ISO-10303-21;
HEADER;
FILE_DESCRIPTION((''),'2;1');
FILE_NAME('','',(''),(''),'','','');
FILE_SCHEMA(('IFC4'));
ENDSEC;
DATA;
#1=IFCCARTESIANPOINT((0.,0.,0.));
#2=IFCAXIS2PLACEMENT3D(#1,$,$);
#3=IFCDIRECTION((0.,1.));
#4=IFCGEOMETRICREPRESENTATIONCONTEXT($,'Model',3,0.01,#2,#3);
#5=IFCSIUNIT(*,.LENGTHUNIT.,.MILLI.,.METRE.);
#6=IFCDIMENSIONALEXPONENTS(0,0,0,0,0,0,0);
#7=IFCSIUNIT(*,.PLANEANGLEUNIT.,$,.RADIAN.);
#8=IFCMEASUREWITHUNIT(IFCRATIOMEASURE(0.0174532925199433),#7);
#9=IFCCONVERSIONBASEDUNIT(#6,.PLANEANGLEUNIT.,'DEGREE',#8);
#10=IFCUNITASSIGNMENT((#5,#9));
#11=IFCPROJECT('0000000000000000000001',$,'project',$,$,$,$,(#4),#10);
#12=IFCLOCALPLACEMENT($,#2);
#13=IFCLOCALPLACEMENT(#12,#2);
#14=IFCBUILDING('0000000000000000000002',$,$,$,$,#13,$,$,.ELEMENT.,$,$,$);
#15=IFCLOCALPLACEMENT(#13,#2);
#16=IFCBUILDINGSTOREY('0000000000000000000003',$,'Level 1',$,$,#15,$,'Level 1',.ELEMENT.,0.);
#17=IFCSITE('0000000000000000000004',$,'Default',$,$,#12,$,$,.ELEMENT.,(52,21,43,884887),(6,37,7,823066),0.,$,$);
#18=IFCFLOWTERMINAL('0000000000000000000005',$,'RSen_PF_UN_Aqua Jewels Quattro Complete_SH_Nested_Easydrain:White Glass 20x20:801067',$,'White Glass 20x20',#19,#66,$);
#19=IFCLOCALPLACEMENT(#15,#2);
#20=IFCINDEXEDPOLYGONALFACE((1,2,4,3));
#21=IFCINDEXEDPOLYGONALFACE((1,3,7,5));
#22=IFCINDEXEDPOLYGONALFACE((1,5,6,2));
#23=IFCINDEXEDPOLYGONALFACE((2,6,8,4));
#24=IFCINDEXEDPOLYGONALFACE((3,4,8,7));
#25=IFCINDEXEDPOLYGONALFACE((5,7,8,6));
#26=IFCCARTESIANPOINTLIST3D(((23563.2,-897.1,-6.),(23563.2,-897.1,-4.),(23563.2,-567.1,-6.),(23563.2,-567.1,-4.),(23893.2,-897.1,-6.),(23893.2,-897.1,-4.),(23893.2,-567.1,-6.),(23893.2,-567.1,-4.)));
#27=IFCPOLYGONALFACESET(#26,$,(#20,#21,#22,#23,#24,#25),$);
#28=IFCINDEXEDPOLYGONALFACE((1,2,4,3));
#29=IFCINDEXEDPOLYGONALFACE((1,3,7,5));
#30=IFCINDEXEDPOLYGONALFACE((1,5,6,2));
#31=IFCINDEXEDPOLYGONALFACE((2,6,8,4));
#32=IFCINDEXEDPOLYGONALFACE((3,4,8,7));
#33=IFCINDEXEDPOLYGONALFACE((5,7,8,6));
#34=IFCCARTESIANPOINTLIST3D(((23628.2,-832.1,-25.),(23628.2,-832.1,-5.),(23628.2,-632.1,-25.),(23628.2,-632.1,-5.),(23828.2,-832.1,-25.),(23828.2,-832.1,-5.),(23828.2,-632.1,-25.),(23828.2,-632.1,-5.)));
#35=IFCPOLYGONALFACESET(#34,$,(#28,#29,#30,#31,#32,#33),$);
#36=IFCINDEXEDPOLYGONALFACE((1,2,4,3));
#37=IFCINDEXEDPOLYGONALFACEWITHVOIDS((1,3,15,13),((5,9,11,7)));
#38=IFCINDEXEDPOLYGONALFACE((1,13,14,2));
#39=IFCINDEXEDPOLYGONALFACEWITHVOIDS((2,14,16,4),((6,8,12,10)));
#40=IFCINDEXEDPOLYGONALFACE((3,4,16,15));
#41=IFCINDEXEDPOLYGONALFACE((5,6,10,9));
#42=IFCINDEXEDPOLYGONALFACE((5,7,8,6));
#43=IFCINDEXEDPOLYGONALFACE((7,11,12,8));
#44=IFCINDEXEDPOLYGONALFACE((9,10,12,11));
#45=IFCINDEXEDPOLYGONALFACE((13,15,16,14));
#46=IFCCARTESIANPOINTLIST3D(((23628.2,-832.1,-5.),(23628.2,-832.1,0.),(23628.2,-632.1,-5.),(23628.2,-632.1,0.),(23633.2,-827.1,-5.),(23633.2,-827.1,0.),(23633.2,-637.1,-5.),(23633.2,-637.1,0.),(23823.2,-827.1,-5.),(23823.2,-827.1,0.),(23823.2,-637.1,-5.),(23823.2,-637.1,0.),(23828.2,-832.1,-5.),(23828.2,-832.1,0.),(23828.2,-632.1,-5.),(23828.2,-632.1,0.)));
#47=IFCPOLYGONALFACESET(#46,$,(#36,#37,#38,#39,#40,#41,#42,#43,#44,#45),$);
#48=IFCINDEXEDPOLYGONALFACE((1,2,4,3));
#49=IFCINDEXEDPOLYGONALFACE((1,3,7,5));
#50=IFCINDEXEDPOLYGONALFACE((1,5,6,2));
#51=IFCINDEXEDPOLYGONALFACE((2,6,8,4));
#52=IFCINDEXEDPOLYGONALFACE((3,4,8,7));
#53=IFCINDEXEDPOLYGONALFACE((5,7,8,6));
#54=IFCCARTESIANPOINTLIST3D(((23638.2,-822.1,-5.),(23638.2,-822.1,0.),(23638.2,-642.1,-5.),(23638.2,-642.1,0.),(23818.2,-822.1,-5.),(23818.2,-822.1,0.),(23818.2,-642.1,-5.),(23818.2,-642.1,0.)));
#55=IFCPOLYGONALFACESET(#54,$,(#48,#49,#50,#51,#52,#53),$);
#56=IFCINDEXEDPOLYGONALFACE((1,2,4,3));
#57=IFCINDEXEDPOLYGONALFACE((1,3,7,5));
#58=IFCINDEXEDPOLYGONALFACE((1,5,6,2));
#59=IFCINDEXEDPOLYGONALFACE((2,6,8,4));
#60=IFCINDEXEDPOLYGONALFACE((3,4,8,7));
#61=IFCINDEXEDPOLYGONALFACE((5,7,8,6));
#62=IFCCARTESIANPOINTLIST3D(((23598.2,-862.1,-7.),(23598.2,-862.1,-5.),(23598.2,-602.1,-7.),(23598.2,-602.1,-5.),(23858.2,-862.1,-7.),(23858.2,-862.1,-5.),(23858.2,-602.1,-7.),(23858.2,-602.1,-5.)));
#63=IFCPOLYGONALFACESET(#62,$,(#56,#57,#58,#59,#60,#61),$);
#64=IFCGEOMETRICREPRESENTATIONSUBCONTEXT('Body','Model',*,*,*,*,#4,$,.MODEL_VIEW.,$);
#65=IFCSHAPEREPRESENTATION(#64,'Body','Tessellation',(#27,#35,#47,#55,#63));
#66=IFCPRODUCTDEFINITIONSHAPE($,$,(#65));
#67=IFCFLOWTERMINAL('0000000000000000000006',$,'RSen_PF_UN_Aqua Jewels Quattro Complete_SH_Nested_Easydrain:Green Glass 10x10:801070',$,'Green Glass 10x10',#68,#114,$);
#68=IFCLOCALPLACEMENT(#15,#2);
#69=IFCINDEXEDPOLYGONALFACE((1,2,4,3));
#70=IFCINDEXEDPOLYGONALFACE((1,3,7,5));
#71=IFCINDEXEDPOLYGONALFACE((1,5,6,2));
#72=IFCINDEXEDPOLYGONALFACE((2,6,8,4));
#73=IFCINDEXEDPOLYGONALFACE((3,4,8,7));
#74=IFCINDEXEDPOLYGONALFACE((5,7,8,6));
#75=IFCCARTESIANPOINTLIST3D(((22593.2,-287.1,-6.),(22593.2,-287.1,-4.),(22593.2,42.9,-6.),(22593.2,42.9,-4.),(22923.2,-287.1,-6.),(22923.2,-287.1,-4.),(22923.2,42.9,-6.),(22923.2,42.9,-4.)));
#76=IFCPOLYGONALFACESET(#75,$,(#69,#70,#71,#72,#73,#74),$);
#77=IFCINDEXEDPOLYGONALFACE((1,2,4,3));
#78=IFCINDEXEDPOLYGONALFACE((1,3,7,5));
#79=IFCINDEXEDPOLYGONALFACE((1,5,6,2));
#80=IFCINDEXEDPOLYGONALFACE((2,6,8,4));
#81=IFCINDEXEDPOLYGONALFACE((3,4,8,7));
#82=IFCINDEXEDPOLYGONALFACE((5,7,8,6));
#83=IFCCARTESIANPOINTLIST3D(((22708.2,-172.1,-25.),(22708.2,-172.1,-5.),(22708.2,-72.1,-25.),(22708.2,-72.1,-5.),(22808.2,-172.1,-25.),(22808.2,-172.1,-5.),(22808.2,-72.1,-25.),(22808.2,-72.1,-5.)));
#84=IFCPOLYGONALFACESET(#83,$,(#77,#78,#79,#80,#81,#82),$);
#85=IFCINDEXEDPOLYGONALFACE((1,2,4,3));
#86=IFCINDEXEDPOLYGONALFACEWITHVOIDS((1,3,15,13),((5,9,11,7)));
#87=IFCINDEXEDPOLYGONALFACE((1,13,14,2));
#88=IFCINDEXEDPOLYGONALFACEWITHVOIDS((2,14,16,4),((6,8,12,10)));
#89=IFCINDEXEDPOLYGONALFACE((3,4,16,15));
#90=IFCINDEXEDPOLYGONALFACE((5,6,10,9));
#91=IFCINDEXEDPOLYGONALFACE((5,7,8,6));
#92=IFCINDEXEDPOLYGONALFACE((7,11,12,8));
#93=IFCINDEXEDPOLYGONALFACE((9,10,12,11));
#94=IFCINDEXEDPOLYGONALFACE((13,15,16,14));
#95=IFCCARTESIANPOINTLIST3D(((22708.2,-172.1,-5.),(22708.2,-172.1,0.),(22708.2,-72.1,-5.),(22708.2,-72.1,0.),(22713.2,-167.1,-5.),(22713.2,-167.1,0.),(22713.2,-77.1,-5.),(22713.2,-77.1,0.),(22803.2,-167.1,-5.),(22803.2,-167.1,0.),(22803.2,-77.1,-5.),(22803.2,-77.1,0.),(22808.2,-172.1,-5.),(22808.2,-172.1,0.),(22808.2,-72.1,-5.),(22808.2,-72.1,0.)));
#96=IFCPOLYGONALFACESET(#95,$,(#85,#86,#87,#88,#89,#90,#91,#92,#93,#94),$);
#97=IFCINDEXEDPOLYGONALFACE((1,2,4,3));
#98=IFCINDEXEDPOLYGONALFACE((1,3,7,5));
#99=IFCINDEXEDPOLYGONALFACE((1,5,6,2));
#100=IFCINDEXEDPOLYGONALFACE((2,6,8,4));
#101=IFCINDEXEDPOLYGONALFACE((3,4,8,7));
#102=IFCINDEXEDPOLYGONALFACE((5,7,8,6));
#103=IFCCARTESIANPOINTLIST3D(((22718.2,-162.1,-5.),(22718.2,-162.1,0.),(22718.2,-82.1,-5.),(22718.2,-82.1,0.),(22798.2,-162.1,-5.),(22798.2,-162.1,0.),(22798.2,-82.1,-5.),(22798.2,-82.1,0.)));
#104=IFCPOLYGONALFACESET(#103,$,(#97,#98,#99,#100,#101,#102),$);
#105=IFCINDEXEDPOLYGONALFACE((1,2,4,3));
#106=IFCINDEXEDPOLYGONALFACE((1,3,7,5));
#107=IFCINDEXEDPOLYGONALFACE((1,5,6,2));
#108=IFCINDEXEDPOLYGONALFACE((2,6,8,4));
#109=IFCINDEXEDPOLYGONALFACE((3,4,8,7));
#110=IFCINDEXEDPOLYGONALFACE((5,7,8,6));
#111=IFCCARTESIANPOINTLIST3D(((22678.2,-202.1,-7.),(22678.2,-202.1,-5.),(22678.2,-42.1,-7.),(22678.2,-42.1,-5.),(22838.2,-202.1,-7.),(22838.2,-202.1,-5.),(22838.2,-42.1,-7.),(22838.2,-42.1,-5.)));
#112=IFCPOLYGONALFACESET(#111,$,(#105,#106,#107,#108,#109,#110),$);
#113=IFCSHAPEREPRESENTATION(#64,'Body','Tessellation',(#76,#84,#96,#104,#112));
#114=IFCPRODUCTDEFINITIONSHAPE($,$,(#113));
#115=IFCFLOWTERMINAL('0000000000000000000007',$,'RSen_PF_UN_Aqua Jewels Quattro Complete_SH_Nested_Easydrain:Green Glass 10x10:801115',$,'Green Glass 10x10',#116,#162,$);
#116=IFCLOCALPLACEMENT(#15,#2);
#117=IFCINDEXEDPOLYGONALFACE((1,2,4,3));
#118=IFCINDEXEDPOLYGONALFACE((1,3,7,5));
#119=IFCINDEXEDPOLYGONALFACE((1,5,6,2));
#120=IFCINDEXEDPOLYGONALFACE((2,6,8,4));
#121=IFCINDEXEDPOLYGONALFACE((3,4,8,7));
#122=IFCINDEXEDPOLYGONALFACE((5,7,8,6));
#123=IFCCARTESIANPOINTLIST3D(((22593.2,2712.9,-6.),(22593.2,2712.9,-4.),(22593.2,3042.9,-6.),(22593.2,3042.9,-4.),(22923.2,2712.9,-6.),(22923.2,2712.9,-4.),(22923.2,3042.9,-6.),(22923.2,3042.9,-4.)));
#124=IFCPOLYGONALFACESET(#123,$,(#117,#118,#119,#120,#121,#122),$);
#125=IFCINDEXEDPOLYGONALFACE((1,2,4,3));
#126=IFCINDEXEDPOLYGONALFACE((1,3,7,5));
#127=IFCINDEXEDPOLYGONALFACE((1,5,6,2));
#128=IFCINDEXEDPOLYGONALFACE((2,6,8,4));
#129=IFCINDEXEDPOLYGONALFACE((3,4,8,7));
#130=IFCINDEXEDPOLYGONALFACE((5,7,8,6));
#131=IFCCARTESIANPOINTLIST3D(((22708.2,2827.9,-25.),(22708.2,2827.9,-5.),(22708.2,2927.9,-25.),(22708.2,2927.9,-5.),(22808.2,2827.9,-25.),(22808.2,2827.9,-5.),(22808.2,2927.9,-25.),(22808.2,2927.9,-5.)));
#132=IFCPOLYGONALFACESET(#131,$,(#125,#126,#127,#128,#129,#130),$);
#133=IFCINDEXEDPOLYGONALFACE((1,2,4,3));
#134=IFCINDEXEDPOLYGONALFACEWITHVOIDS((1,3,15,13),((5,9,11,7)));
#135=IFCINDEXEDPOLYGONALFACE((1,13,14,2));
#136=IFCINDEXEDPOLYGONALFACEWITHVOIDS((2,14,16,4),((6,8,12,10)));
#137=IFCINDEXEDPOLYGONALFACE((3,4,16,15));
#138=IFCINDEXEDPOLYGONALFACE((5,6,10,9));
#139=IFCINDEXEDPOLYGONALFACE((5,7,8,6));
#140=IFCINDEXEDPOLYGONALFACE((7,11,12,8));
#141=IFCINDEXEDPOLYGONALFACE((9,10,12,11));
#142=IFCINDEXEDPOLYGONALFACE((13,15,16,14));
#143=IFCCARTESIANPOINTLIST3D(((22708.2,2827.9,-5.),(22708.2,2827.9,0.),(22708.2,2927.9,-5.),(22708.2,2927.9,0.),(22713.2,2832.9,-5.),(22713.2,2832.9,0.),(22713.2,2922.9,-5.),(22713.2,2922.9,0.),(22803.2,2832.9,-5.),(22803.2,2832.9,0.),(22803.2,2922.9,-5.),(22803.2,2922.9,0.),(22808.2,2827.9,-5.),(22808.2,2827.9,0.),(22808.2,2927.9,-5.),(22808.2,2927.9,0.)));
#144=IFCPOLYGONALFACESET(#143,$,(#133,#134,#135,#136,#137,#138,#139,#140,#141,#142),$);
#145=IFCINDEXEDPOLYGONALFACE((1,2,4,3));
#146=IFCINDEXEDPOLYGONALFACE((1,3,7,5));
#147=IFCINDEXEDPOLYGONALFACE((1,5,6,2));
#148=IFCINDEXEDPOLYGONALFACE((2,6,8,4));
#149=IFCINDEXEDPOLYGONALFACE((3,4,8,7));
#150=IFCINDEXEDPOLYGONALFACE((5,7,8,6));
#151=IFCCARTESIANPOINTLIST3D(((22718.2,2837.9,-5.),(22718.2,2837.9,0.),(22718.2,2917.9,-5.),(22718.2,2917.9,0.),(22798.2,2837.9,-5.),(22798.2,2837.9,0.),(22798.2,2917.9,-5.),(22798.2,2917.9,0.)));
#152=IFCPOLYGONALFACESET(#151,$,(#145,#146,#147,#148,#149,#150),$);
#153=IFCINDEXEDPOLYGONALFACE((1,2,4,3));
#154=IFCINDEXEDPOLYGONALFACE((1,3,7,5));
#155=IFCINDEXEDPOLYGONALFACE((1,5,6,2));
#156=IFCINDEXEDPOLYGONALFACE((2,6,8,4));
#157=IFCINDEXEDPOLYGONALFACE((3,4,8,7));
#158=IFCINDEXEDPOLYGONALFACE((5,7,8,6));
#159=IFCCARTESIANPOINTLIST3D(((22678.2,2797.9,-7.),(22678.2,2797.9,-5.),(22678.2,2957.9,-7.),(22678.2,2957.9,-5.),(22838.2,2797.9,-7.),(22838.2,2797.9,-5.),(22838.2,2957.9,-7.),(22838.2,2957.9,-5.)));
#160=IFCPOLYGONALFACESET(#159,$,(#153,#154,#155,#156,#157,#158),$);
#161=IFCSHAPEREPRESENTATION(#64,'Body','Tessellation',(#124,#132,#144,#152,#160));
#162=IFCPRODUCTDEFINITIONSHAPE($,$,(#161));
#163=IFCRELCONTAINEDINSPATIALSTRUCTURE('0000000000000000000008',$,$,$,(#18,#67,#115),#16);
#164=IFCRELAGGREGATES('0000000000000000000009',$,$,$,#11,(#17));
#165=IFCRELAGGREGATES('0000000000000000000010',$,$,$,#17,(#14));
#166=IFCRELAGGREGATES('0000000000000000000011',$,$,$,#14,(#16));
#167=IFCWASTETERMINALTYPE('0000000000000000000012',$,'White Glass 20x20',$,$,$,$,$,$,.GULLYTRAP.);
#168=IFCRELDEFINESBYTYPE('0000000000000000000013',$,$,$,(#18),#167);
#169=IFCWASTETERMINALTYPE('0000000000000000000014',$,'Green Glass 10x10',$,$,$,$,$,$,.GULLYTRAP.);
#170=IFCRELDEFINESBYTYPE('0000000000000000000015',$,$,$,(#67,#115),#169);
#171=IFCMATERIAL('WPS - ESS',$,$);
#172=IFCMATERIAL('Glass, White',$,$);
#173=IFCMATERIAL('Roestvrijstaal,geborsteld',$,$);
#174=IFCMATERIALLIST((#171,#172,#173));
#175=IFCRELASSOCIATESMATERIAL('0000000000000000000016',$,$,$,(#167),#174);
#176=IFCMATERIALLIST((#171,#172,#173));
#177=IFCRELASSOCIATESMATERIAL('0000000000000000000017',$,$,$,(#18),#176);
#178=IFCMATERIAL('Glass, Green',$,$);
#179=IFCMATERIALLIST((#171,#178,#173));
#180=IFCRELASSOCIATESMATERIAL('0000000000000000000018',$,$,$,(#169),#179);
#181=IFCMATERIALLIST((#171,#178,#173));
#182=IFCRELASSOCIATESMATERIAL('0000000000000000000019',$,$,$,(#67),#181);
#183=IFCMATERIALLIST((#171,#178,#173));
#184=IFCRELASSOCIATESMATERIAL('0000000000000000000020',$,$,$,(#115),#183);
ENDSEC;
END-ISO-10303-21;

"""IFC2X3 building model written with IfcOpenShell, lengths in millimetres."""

from ifc_helpers import new_model, entity, si_unit, converted_unit, direction, frame, frame_2d, origin, origin_2d_with_axis, place, context, subcontext, project, spatial, polyline, rectangle, outline, extrude, source, transform, mapped, material, material_list, type_object, type_shapes, element, save


model = new_model("IFC2X3")

# Units and contexts
model_context = context("Model", 3, precision=0.01, world=origin(), true_north=direction((0.0, 1.0)))
body_context = subcontext(model_context, "Body", "Model", "MODEL_VIEW")
ifc_project = project(units=[si_unit("LENGTHUNIT", "METRE", prefix="MILLI"), converted_unit("PLANEANGLEUNIT", "DEGREE", entity("IfcRatioMeasure", 0.0174532925199433), si_unit("PLANEANGLEUNIT", "RADIAN"), dimensions=[0, 0, 0, 0, 0, 0, 0])], contexts=[model_context])

# Site, building, storey
site_placement = place(None, origin())
site = spatial("IfcSite", under=ifc_project, at=site_placement, Name="Default", CompositionType="ELEMENT", RefLatitude=(52, 21, 43, 884887), RefLongitude=(6, 37, 7, 823066), RefElevation=0.0)
building_placement = place(site_placement, origin())
building = spatial("IfcBuilding", under=site, at=building_placement, CompositionType="ELEMENT")
storey_placement = place(building_placement, origin())
storey = spatial("IfcBuildingStorey", under=building, at=storey_placement, Name="Level 1", LongName="Level 1", CompositionType="ELEMENT", Elevation=0.0)

# Flow terminals
ifc_material_1 = material(Name="WPS - ESS")
ifc_material_2 = material(Name="Roestvrijstaal,geborsteld")
ifc_material_3 = material(Name="Glass, White")
ifc_material_list_1 = material_list([ifc_material_1, ifc_material_3, ifc_material_2])
ifc_material_list_2 = material_list([ifc_material_1, ifc_material_3, ifc_material_2])
waste_terminal_type_1 = type_object("IfcWasteTerminalType", Name="White Glass 20x20", PredefinedType="GULLYTRAP", material=ifc_material_list_2)
shared_shape_1 = source(origin(), body_context, "Body", "SweptSolid", [
    extrude(rectangle(XDim=330.0, YDim=330.0, at=origin_2d_with_axis()), frame((5.0, -10.0, -6.0), z_axis=(0.0, 0.0, 1.0), x_axis=(-1.0, 0.0, 0.0)), (0.0, 0.0, 1.0), 2.0),
    extrude(rectangle(XDim=200.0, YDim=200.0, at=origin_2d_with_axis()), frame((5.0, -10.0, -25.0), z_axis=(0.0, 0.0, 1.0), x_axis=(-1.0, 0.0, 0.0)), (0.0, 0.0, 1.0), 20.0),
    extrude(outline(polyline([(-100.0, -100.0), (100.0, -100.0), (100.0, 100.0), (-100.0, 100.0), (-100.0, -100.0)]), holes=[polyline([(-95.0, -95.0), (-95.0, 95.0), (95.0, 95.0), (95.0, -95.0), (-95.0, -95.0)])]), frame((5.0, -10.0, -5.0), z_axis=(0.0, 0.0, 1.0), x_axis=(-1.0, 0.0, 0.0)), (0.0, 0.0, 1.0), 5.0),
    extrude(rectangle(XDim=180.0, YDim=180.0, at=frame_2d((0.0, 0.0), x_axis=(1.0, 0.0))), frame((5.0, -10.0, -5.0), z_axis=(0.0, 0.0, 1.0), x_axis=(-1.0, 0.0, 0.0)), (0.0, 0.0, 1.0), 5.0),
    extrude(rectangle(XDim=260.0, YDim=260.0, at=origin_2d_with_axis()), frame((5.0, -10.0, -7.0), z_axis=(0.0, 0.0, 1.0), x_axis=(-1.0, 0.0, 0.0)), (0.0, 0.0, 1.0), 2.0),
])
type_shapes(waste_terminal_type_1, [shared_shape_1])
flow_terminal_1_placement = place(storey_placement, frame((23723.2, -722.1, 0.0)))
element("IfcFlowTerminal", 1, at=flow_terminal_1_placement, inside=storey, type_object=waste_terminal_type_1, material=ifc_material_list_1, Name="RSen_PF_UN_Aqua Jewels Quattro Complete_SH_Nested_Easydrain:White Glass 20x20:801067", ObjectType="White Glass 20x20", context=body_context, shape_type="MappedRepresentation", body=[
    mapped(shared_shape_1, transform((0.0, 0.0, 0.0), scale=1.0)),
])
ifc_material_4 = material(Name="Glass, Green")
ifc_material_list_3 = material_list([ifc_material_1, ifc_material_4, ifc_material_2])
ifc_material_list_4 = material_list([ifc_material_1, ifc_material_4, ifc_material_2])
waste_terminal_type_2 = type_object("IfcWasteTerminalType", Name="Green Glass 10x10", PredefinedType="GULLYTRAP", material=ifc_material_list_4)
shared_shape_2 = source(origin(), body_context, "Body", "SweptSolid", [
    extrude(rectangle(XDim=330.0, YDim=330.0, at=origin_2d_with_axis()), frame((0.0, 0.0, -6.0), z_axis=(0.0, 0.0, 1.0), x_axis=(-1.0, 0.0, 0.0)), (0.0, 0.0, 1.0), 2.0),
    extrude(rectangle(XDim=100.0, YDim=100.0, at=origin_2d_with_axis()), frame((0.0, 0.0, -25.0), z_axis=(0.0, 0.0, 1.0), x_axis=(-1.0, 0.0, 0.0)), (0.0, 0.0, 1.0), 20.0),
    extrude(outline(polyline([(-50.0, -50.0), (50.0, -50.0), (50.0, 50.0), (-50.0, 50.0), (-50.0, -50.0)]), holes=[polyline([(-45.0, -45.0), (-45.0, 45.0), (45.0, 45.0), (45.0, -45.0), (-45.0, -45.0)])]), frame((0.0, 0.0, -5.0), z_axis=(0.0, 0.0, 1.0), x_axis=(-1.0, 0.0, 0.0)), (0.0, 0.0, 1.0), 5.0),
    extrude(rectangle(XDim=80.0, YDim=80.0, at=origin_2d_with_axis()), frame((0.0, 0.0, -5.0), z_axis=(0.0, 0.0, 1.0), x_axis=(-1.0, 0.0, 0.0)), (0.0, 0.0, 1.0), 5.0),
    extrude(rectangle(XDim=160.0, YDim=160.0, at=origin_2d_with_axis()), frame((0.0, 0.0, -7.0), z_axis=(0.0, 0.0, 1.0), x_axis=(-1.0, 0.0, 0.0)), (0.0, 0.0, 1.0), 2.0),
])
type_shapes(waste_terminal_type_2, [shared_shape_2])
flow_terminal_2_placement = place(storey_placement, frame((22758.2, -122.1, 0.0)))
element("IfcFlowTerminal", 2, at=flow_terminal_2_placement, inside=storey, type_object=waste_terminal_type_2, material=ifc_material_list_3, Name="RSen_PF_UN_Aqua Jewels Quattro Complete_SH_Nested_Easydrain:Green Glass 10x10:801070", ObjectType="Green Glass 10x10", context=body_context, shape_type="MappedRepresentation", body=[
    mapped(shared_shape_2, transform((0.0, 0.0, 0.0), scale=1.0)),
])
ifc_material_list_5 = material_list([ifc_material_1, ifc_material_4, ifc_material_2])
flow_terminal_3_placement = place(storey_placement, frame((22758.2, 2877.9, 0.0)))
element("IfcFlowTerminal", 3, at=flow_terminal_3_placement, inside=storey, type_object=waste_terminal_type_2, material=ifc_material_list_5, Name="RSen_PF_UN_Aqua Jewels Quattro Complete_SH_Nested_Easydrain:Green Glass 10x10:801115", ObjectType="Green Glass 10x10", context=body_context, shape_type="MappedRepresentation", body=[
    mapped(shared_shape_2, transform((0.0, 0.0, 0.0), scale=1.0)),
])

save(model, "model.ifc")
